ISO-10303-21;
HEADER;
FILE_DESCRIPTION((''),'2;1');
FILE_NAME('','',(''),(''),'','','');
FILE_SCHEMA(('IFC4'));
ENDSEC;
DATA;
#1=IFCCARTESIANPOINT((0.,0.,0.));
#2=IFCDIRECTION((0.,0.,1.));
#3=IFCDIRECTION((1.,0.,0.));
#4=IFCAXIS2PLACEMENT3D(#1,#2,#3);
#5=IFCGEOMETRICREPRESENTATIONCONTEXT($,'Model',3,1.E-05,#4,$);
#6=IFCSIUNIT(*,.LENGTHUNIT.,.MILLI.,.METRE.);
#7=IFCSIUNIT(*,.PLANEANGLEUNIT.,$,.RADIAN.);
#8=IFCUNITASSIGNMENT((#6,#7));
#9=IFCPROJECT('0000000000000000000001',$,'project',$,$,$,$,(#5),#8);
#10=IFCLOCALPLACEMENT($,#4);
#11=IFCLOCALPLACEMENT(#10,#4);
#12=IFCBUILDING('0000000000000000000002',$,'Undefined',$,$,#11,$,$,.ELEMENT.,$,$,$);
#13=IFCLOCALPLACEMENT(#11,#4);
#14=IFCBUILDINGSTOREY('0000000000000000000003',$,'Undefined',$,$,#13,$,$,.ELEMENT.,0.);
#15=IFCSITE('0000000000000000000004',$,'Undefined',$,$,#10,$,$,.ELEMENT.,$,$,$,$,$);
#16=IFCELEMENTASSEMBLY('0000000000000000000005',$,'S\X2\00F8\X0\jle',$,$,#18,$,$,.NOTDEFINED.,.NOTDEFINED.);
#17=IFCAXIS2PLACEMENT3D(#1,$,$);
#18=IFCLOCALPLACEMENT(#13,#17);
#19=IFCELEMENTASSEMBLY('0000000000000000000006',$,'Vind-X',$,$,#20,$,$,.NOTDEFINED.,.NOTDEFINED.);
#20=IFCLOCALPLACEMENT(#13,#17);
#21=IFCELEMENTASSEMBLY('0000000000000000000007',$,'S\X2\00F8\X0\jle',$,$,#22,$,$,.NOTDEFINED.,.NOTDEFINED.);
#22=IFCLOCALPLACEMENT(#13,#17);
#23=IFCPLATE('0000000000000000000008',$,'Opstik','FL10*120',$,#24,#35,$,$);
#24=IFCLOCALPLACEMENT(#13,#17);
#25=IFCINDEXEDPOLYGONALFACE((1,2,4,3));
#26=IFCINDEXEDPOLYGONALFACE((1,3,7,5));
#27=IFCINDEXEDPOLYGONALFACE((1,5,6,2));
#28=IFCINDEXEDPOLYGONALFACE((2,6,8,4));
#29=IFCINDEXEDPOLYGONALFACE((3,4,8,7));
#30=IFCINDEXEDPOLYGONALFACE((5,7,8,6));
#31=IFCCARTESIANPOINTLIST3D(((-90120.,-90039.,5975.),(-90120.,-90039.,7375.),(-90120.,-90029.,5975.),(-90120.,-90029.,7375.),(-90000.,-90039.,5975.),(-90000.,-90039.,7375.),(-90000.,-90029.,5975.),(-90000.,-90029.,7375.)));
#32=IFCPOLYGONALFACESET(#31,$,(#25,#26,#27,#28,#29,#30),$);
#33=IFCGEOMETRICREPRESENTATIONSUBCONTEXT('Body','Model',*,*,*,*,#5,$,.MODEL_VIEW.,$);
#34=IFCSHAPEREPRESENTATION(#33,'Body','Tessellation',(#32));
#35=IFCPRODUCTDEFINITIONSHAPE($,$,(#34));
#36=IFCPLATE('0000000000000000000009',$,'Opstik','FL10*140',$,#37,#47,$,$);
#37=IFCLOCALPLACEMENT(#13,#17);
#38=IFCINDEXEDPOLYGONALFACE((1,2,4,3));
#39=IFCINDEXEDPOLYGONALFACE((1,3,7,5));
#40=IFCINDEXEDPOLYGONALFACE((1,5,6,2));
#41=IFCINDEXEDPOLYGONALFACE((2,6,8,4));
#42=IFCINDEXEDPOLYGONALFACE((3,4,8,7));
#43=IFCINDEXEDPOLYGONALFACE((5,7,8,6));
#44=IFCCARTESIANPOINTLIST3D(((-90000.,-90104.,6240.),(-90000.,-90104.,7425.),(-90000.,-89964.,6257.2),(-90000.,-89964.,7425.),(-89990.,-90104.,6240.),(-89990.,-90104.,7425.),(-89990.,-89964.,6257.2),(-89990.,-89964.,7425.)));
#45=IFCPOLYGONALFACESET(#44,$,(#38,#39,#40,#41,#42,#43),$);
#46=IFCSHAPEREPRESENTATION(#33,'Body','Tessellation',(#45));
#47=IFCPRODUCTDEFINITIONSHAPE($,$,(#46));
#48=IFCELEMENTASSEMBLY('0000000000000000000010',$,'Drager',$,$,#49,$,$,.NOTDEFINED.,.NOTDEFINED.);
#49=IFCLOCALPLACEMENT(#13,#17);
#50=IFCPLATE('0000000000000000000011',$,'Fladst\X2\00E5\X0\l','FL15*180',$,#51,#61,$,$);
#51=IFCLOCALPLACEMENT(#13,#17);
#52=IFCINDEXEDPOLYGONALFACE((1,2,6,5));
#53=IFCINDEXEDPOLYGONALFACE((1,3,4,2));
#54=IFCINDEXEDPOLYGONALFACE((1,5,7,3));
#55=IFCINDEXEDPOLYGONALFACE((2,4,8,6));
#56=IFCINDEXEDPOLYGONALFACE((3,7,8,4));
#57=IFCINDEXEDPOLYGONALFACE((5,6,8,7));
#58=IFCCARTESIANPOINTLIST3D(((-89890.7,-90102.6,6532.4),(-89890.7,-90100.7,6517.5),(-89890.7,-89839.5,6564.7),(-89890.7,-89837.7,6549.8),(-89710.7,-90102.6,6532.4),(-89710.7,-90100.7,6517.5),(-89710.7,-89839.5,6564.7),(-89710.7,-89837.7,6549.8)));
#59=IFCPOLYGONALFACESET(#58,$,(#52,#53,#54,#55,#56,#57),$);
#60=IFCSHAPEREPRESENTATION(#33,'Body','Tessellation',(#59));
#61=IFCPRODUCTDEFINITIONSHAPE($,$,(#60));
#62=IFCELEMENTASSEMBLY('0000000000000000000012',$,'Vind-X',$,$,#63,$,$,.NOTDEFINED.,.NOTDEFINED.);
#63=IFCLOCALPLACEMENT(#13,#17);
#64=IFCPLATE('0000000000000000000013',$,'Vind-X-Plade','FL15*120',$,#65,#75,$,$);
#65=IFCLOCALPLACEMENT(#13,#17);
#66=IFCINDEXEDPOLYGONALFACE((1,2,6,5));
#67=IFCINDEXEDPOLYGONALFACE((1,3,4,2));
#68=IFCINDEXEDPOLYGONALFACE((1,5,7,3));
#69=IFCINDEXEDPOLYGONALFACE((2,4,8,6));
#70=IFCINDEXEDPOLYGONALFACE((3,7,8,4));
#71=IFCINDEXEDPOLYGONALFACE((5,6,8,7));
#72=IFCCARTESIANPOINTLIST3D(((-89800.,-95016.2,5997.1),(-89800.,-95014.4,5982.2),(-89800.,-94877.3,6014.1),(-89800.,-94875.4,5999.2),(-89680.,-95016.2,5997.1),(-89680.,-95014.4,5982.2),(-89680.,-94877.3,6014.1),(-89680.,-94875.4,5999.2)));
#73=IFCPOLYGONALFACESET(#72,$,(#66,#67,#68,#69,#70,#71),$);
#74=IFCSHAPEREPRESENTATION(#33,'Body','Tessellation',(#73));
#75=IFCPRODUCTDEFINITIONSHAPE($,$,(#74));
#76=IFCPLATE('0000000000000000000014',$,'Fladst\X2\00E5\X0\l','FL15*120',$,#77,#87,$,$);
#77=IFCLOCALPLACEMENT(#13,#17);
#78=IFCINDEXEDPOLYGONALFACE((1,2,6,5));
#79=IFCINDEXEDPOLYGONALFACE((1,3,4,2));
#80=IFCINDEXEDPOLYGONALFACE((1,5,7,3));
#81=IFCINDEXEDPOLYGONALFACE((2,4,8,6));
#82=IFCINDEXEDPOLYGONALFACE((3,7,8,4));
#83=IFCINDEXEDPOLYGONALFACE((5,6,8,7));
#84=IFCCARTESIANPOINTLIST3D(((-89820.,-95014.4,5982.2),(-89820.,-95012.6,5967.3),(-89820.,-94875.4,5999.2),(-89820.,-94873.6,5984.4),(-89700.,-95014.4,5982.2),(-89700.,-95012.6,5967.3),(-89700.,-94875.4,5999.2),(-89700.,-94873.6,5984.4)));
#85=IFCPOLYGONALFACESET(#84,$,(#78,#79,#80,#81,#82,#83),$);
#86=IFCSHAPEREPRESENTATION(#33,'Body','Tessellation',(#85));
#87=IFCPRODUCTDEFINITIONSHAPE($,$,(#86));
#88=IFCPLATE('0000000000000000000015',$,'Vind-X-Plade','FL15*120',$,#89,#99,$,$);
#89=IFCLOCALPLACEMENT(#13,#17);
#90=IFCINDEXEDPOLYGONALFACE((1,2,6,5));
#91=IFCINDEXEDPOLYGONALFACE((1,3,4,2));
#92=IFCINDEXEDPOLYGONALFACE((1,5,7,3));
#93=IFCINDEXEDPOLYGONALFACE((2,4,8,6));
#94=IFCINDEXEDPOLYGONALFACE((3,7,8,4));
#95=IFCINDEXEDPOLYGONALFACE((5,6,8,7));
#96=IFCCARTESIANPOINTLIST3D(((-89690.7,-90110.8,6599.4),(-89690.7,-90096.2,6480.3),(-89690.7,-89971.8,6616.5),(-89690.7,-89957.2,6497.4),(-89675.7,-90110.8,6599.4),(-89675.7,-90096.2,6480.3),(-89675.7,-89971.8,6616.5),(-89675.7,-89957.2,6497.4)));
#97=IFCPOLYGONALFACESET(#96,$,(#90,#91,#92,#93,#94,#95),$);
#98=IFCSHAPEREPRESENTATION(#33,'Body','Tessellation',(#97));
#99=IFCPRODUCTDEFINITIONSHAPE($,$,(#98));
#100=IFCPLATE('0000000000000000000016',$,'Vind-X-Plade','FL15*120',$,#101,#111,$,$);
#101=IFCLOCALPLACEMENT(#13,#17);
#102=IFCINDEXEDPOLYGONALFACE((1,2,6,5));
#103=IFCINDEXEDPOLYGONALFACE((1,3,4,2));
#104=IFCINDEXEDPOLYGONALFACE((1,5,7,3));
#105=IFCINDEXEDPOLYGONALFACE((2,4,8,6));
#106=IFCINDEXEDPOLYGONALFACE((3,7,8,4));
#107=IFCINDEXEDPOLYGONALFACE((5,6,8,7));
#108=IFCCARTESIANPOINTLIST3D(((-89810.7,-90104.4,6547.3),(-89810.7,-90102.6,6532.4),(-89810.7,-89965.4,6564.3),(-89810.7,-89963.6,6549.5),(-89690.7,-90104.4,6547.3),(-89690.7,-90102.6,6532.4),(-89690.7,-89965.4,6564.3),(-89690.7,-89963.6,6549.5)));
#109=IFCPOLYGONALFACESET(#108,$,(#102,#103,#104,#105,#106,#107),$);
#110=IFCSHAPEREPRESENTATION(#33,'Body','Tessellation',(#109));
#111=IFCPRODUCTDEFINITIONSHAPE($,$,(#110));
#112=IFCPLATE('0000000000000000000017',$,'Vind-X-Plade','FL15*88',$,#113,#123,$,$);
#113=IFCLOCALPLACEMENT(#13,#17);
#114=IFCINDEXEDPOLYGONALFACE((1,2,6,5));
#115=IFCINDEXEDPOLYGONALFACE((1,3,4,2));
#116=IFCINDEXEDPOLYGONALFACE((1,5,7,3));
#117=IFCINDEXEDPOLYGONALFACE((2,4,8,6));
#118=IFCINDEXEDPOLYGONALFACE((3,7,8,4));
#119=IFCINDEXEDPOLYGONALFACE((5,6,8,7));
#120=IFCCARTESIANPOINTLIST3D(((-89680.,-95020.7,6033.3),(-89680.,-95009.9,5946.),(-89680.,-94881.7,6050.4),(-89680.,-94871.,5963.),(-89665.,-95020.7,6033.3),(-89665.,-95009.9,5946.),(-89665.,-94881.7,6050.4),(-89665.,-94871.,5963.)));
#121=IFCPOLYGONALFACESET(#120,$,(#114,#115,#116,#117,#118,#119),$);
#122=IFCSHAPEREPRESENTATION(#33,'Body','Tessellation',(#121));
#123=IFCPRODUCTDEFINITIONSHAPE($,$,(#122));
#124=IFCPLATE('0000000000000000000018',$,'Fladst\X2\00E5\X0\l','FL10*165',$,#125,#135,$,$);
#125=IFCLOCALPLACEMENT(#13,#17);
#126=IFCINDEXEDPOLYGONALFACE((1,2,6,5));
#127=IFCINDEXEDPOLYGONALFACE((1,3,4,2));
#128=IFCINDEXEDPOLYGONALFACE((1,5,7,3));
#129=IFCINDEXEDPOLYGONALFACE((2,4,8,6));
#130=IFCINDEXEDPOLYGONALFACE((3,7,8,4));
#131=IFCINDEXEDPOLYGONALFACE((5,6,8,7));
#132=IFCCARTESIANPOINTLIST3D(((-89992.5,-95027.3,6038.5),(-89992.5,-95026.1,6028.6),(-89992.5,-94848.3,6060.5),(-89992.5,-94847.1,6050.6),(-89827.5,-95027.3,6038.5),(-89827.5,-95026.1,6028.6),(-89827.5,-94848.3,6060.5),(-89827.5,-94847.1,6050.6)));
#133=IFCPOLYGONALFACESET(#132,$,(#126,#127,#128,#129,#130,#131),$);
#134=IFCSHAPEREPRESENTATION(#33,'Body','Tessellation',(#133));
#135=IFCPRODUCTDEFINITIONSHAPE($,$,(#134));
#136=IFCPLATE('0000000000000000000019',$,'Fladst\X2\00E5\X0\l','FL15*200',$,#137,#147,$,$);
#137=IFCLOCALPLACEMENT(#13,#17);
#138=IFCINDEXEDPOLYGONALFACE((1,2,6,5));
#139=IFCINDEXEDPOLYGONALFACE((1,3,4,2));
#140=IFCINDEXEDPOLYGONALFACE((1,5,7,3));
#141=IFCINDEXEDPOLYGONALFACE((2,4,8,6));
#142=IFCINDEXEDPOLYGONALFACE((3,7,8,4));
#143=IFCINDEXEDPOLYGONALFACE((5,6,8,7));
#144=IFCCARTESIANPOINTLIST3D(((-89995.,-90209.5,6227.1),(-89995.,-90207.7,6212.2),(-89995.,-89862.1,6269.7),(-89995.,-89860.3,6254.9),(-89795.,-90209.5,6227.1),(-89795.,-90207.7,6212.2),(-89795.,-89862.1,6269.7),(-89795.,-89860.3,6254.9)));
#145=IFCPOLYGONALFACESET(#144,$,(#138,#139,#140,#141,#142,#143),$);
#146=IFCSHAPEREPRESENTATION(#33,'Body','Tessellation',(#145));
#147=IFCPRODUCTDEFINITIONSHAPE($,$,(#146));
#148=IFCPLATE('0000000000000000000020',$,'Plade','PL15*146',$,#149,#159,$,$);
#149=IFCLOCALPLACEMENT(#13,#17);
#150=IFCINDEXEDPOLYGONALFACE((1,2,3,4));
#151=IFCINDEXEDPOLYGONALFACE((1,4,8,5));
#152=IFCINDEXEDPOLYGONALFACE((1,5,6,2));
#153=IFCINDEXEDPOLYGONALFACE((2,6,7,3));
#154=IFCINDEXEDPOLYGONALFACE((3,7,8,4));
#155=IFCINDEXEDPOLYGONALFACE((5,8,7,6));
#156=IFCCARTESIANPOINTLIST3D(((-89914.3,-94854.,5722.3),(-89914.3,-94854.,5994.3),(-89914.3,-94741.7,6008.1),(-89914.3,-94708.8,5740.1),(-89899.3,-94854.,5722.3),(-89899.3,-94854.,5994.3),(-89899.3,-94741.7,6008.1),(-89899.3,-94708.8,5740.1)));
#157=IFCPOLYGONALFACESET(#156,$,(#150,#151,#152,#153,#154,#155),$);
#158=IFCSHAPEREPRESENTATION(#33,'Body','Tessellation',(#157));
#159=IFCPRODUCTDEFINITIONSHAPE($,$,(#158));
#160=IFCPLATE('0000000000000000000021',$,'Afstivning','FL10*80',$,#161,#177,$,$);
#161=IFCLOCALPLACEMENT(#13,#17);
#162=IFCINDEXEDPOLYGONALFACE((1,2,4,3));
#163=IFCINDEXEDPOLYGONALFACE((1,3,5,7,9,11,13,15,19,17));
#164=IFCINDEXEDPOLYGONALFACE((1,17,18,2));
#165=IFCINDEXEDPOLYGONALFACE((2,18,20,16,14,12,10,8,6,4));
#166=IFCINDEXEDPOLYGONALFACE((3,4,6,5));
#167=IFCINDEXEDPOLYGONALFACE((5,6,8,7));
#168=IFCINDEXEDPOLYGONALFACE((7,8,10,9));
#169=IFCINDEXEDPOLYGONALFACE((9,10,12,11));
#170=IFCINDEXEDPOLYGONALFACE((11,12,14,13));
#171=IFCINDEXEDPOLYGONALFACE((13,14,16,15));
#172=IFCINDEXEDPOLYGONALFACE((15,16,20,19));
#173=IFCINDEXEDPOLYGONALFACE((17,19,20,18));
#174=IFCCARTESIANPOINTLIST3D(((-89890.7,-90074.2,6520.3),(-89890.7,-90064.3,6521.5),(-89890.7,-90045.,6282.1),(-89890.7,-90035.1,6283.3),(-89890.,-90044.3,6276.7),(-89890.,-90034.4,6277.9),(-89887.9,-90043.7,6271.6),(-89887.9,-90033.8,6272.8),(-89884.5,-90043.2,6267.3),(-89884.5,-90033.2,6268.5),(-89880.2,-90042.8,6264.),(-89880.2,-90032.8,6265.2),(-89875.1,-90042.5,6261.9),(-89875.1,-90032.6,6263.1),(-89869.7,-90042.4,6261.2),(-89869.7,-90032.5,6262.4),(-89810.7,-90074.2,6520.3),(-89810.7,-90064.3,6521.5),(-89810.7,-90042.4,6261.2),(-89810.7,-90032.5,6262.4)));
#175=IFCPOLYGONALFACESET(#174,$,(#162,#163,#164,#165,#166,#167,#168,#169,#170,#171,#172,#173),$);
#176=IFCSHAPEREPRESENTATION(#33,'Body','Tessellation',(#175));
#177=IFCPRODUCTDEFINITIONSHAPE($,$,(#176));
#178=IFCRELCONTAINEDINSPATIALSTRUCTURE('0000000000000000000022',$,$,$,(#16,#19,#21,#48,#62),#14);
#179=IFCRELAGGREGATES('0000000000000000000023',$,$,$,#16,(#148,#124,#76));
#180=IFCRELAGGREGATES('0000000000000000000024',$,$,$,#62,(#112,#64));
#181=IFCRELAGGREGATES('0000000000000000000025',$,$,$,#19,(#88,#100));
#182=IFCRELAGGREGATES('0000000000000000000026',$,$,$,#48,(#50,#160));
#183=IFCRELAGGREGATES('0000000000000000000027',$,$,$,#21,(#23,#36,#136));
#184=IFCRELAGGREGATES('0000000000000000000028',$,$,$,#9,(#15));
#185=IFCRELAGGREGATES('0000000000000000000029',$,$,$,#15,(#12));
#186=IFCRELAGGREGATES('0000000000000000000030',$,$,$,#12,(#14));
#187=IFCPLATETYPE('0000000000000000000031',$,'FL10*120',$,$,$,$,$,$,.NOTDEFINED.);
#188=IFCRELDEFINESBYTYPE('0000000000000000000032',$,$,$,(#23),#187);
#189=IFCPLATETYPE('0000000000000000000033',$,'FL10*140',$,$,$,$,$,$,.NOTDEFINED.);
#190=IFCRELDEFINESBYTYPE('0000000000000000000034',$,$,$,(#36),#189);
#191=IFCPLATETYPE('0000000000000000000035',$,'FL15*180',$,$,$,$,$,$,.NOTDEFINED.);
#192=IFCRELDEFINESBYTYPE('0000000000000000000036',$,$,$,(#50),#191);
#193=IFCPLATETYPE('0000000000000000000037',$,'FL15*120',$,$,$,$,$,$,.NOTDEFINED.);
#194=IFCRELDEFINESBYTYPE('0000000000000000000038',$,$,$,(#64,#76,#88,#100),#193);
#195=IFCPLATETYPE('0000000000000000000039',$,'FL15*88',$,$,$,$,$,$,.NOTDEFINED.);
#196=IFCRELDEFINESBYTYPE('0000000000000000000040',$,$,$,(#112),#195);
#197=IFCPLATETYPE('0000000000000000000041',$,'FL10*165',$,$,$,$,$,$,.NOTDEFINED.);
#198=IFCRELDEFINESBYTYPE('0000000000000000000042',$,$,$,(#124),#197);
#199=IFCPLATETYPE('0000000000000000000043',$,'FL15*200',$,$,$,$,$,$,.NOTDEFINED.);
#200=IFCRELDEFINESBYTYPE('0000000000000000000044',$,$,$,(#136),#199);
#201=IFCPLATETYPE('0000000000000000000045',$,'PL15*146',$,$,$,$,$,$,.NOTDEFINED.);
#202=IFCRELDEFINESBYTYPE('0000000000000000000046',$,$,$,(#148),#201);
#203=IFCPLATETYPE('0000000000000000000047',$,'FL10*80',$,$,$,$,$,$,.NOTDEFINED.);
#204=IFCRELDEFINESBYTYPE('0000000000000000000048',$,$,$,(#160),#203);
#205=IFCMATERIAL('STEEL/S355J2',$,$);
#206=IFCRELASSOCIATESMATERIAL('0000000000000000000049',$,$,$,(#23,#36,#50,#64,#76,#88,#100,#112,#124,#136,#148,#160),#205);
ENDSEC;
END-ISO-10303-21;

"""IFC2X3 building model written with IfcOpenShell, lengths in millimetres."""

from ifc_helpers import new_model, si_unit, frame, frame_2d, origin_with_axes, place, context, subcontext, project, spatial, polyline, circle_curve, parameter, trimmed, segment, composite_curve, outline, extrude, material, type_object, element, aggregate, save


model = new_model("IFC2X3")

# Units and contexts
model_context = context("Model", 3, precision=1e-05, world=origin_with_axes())
body_context = subcontext(model_context, "Body", "Model", "MODEL_VIEW")
ifc_project = project(units=[si_unit("LENGTHUNIT", "METRE", prefix="MILLI"), si_unit("PLANEANGLEUNIT", "RADIAN")], contexts=[model_context])

# Site, building, storey
site_placement = place(None, origin_with_axes())
site = spatial("IfcSite", under=ifc_project, at=site_placement, Name="Undefined", CompositionType="ELEMENT")
building_placement = place(site_placement, origin_with_axes())
building = spatial("IfcBuilding", under=site, at=building_placement, Name="Undefined", CompositionType="ELEMENT")
storey_placement = place(building_placement, origin_with_axes())
storey = spatial("IfcBuildingStorey", under=building, at=storey_placement, Name="Undefined", CompositionType="ELEMENT", Elevation=0.0)

# Element assembly
assembly_1_placement = place(storey_placement, origin_with_axes())
assembly_1 = element("IfcElementAssembly", 1, at=assembly_1_placement, inside=storey, Name="Søjle", AssemblyPlace="NOTDEFINED", PredefinedType="NOTDEFINED")
ifc_material_1 = material(Name="STEEL/S355J2")

# Element assembly
assembly_2_placement = place(storey_placement, origin_with_axes())
assembly_2 = element("IfcElementAssembly", 2, at=assembly_2_placement, inside=storey, Name="Vind-X", AssemblyPlace="NOTDEFINED", PredefinedType="NOTDEFINED")

# Element assembly, plates
assembly_3_placement = place(storey_placement, origin_with_axes())
assembly_3 = element("IfcElementAssembly", 3, at=assembly_3_placement, inside=storey, Name="Søjle", AssemblyPlace="NOTDEFINED", PredefinedType="NOTDEFINED")
plate_type_1 = type_object("IfcPlateType", Name="FL10*120", PredefinedType="NOTDEFINED")
plate_1_placement = place(assembly_3_placement, frame((-90000.0, -90034.0, 5975.0), z_axis=(0.0, -1.0, 0.0), x_axis=(0.0, 0.0, 1.0)))
plate_1 = element("IfcPlate", 4, at=plate_1_placement, type_object=plate_type_1, material=ifc_material_1, Name="Opstik", Description="FL10*120", context=body_context, shape_type="SweptSolid", body=[
    extrude(outline(polyline([(0.0, 0.0), (1400.0, 0.0), (1400.0, 120.0), (1400.0, 120.0), (0.0, 120.0), (0.0, 120.0), (0.0, 0.0)])), frame((0.0, 0.0, -5.0), z_axis=(0.0, 0.0, 1.0), x_axis=(1.0, 0.0, 0.0)), (0.0, 0.0, 1.0), 10.0),
])
plate_type_2 = type_object("IfcPlateType", Name="FL10*140", PredefinedType="NOTDEFINED")
plate_2_placement = place(assembly_3_placement, frame((-89995.0, -90104.0, 6240.0), z_axis=(-1.0, 0.0, 0.0), x_axis=(0.0, 0.0, 1.0)))
plate_2 = element("IfcPlate", 5, at=plate_2_placement, type_object=plate_type_2, material=ifc_material_1, Name="Opstik", Description="FL10*140", context=body_context, shape_type="SweptSolid", body=[
    extrude(outline(polyline([(0.0, 0.0), (1185.0, 0.0), (1185.0, 0.0), (1185.0, 140.0), (1185.0, 140.0), (17.2, 140.0), (0.0, 0.0)])), frame((0.0, 0.0, -5.0), z_axis=(0.0, 0.0, 1.0), x_axis=(1.0, 0.0, 0.0)), (0.0, 0.0, 1.0), 10.0),
])

# Element assemblies, plates
assembly_4_placement = place(storey_placement, origin_with_axes())
assembly_4 = element("IfcElementAssembly", 6, at=assembly_4_placement, inside=storey, Name="Drager", AssemblyPlace="NOTDEFINED", PredefinedType="NOTDEFINED")
plate_type_3 = type_object("IfcPlateType", Name="FL15*180", PredefinedType="NOTDEFINED")
plate_3_placement = place(assembly_4_placement, frame((-89890.7, -89838.6, 6557.3), z_axis=(0.0, -0.121869, 0.992546), x_axis=(0.0, -0.992546, -0.121869)))
plate_3 = element("IfcPlate", 7, at=plate_3_placement, type_object=plate_type_3, material=ifc_material_1, Name="Fladstål", Description="FL15*180", context=body_context, shape_type="SweptSolid", body=[
    extrude(outline(polyline([(0.0, 0.0), (265.0, 0.0), (265.0, 180.0), (0.0, 180.0), (0.0, 0.0)])), frame((0.0, 0.0, -7.5), z_axis=(0.0, 0.0, 1.0), x_axis=(1.0, 0.0, 0.0)), (0.0, 0.0, 1.0), 15.0),
])
assembly_5_placement = place(storey_placement, origin_with_axes())
assembly_5 = element("IfcElementAssembly", 8, at=assembly_5_placement, inside=storey, Name="Vind-X", AssemblyPlace="NOTDEFINED", PredefinedType="NOTDEFINED")
plate_type_4 = type_object("IfcPlateType", Name="FL15*120", PredefinedType="NOTDEFINED")
plate_4_placement = place(assembly_5_placement, frame((-89800.0, -94945.8, 5998.2), z_axis=(0.0, 0.121869, -0.992546), x_axis=(1.0, 0.0, 0.0)))
plate_4 = element("IfcPlate", 9, at=plate_4_placement, type_object=plate_type_4, material=ifc_material_1, Name="Vind-X-Plade", Description="FL15*120", context=body_context, shape_type="SweptSolid", body=[
    extrude(outline(polyline([(0.0, -70.0), (0.0, 70.0), (120.0, 70.0), (120.0, -70.0), (0.0, -70.0)])), frame((0.0, 0.0, -7.5), z_axis=(0.0, 0.0, 1.0), x_axis=(1.0, 0.0, 0.0)), (0.0, 0.0, 1.0), 15.0),
])

# Plates
plate_5_placement = place(assembly_1_placement, frame((-89820.0, -94874.5, 5991.8), z_axis=(0.0, -0.121869, 0.992546), x_axis=(0.0, -0.992546, -0.121869)))
plate_5 = element("IfcPlate", 10, at=plate_5_placement, type_object=plate_type_4, material=ifc_material_1, Name="Fladstål", Description="FL15*120", context=body_context, shape_type="SweptSolid", body=[
    extrude(outline(polyline([(0.0, 0.0), (140.0, 0.0), (140.0, 120.0), (0.0, 120.0), (0.0, 0.0)])), frame((0.0, 0.0, -7.5), z_axis=(0.0, 0.0, 1.0), x_axis=(1.0, 0.0, 0.0)), (0.0, 0.0, 1.0), 15.0),
])
plate_6_placement = place(assembly_2_placement, frame((-89683.2, -89957.2, 6497.4), z_axis=(-1.0, 0.0, 0.0), x_axis=(0.0, -0.992546, -0.121869)))
plate_6 = element("IfcPlate", 11, at=plate_6_placement, type_object=plate_type_4, material=ifc_material_1, Name="Vind-X-Plade", Description="FL15*120", context=body_context, shape_type="SweptSolid", body=[
    extrude(outline(polyline([(0.0, 0.0), (140.0, 0.0), (140.0, 120.0), (0.0, 120.0), (0.0, 0.0)])), frame((0.0, 0.0, -7.5), z_axis=(0.0, 0.0, 1.0), x_axis=(1.0, 0.0, 0.0)), (0.0, 0.0, 1.0), 15.0),
])
plate_7_placement = place(assembly_2_placement, frame((-89810.7, -90034.0, 6548.4), z_axis=(0.0, 0.121869, -0.992546), x_axis=(1.0, 0.0, 0.0)))
plate_7 = element("IfcPlate", 12, at=plate_7_placement, type_object=plate_type_4, material=ifc_material_1, Name="Vind-X-Plade", Description="FL15*120", context=body_context, shape_type="SweptSolid", body=[
    extrude(outline(polyline([(0.0, -70.0), (0.0, 70.0), (120.0, 70.0), (120.0, -70.0), (0.0, -70.0)])), frame((0.0, 0.0, -7.5), z_axis=(0.0, 0.0, 1.0), x_axis=(1.0, 0.0, 0.0)), (0.0, 0.0, 1.0), 15.0),
])
plate_type_5 = type_object("IfcPlateType", Name="FL15*88", PredefinedType="NOTDEFINED")
plate_8_placement = place(assembly_5_placement, frame((-89672.5, -94871.0, 5963.0), z_axis=(-1.0, 0.0, 0.0), x_axis=(0.0, -0.992546, -0.121869)))
plate_8 = element("IfcPlate", 13, at=plate_8_placement, type_object=plate_type_5, material=ifc_material_1, Name="Vind-X-Plade", Description="FL15*88", context=body_context, shape_type="SweptSolid", body=[
    extrude(outline(polyline([(0.0, 0.0), (140.0, 0.0), (140.0, 88.0), (0.0, 88.0), (0.0, 0.0)])), frame((0.0, 0.0, -7.5), z_axis=(0.0, 0.0, 1.0), x_axis=(1.0, 0.0, 0.0)), (0.0, 0.0, 1.0), 15.0),
])
plate_type_6 = type_object("IfcPlateType", Name="FL10*165", PredefinedType="NOTDEFINED")
plate_9_placement = place(assembly_1_placement, frame((-89910.0, -95026.7, 6033.6), z_axis=(0.0, 0.121869, -0.992546), x_axis=(0.0, 0.992546, 0.121869)))
plate_9 = element("IfcPlate", 14, at=plate_9_placement, type_object=plate_type_6, material=ifc_material_1, Name="Fladstål", Description="FL10*165", context=body_context, shape_type="SweptSolid", body=[
    extrude(outline(polyline([(0.0, -82.5), (0.0, 82.5), (180.4, 82.5), (180.4, -82.5), (0.0, -82.5)])), frame((0.0, 0.0, -5.0), z_axis=(0.0, 0.0, 1.0), x_axis=(1.0, 0.0, 0.0)), (0.0, 0.0, 1.0), 10.0),
])
plate_type_7 = type_object("IfcPlateType", Name="FL15*200", PredefinedType="NOTDEFINED")
plate_10_placement = place(assembly_3_placement, frame((-89895.0, -90208.6, 6219.6), z_axis=(0.0, 0.121869, -0.992546), x_axis=(0.0, 0.992546, 0.121869)))
plate_10 = element("IfcPlate", 15, at=plate_10_placement, type_object=plate_type_7, material=ifc_material_1, Name="Fladstål", Description="FL15*200", context=body_context, shape_type="SweptSolid", body=[
    extrude(outline(polyline([(0.0, -100.0), (0.0, 100.0), (350.0, 100.0), (350.0, -100.0), (0.0, -100.0)])), frame((0.0, 0.0, -7.5), z_axis=(0.0, 0.0, 1.0), x_axis=(1.0, 0.0, 0.0)), (0.0, 0.0, 1.0), 15.0),
])
plate_type_8 = type_object("IfcPlateType", Name="PL15*146", PredefinedType="NOTDEFINED")
plate_11_placement = place(assembly_1_placement, frame((-89906.8, -94854.0, 5994.3), z_axis=(1.0, 0.0, 0.0), x_axis=(0.0, 0.0, -1.0)))
plate_11 = element("IfcPlate", 16, at=plate_11_placement, type_object=plate_type_8, material=ifc_material_1, Name="Plade", Description="PL15*146", context=body_context, shape_type="SweptSolid", body=[
    extrude(outline(polyline([(0.0, 0.0), (272.0, 0.0), (254.2, 145.2), (-13.8, 112.3), (0.0, 0.0)])), frame((0.0, 0.0, -7.5), z_axis=(0.0, 0.0, 1.0), x_axis=(1.0, 0.0, 0.0)), (0.0, 0.0, 1.0), 15.0),
])
aggregate(assembly_1, [plate_11, plate_9, plate_5])
plate_type_9 = type_object("IfcPlateType", Name="FL10*80", PredefinedType="NOTDEFINED")
plate_12_placement = place(assembly_4_placement, frame((-89890.7, -90037.5, 6261.8), z_axis=(0.0, -0.992546, -0.121869), x_axis=(1.0, 0.0, 0.0)))
plate_12 = element("IfcPlate", 17, at=plate_12_placement, type_object=plate_type_9, material=ifc_material_1, Name="Afstivning", Description="FL10*80", context=body_context, shape_type="SweptSolid", body=[
    extrude(outline(composite_curve([segment(trimmed(circle_curve(frame_2d((21.0, 21.0), x_axis=(-1.0, 0.0)), 21.0), [parameter(0.0)], [parameter(1.570796)], True, "PARAMETER"), True, "CONTINUOUS"), segment(polyline([(21.0, 0.0), (80.0, 0.0), (80.0, 261.0), (0.0, 261.0), (0.0, 21.0)]), True, "CONTINUOUS")], self_intersect=True)), frame((0.0, 0.0, -5.0), z_axis=(0.0, 0.0, 1.0), x_axis=(1.0, 0.0, 0.0)), (0.0, 0.0, 1.0), 10.0),
])

aggregate(assembly_5, [plate_8, plate_4])
aggregate(assembly_2, [plate_6, plate_7])
aggregate(assembly_4, [plate_3, plate_12])
aggregate(assembly_3, [plate_1, plate_2, plate_10])

save(model, "model.ifc")
